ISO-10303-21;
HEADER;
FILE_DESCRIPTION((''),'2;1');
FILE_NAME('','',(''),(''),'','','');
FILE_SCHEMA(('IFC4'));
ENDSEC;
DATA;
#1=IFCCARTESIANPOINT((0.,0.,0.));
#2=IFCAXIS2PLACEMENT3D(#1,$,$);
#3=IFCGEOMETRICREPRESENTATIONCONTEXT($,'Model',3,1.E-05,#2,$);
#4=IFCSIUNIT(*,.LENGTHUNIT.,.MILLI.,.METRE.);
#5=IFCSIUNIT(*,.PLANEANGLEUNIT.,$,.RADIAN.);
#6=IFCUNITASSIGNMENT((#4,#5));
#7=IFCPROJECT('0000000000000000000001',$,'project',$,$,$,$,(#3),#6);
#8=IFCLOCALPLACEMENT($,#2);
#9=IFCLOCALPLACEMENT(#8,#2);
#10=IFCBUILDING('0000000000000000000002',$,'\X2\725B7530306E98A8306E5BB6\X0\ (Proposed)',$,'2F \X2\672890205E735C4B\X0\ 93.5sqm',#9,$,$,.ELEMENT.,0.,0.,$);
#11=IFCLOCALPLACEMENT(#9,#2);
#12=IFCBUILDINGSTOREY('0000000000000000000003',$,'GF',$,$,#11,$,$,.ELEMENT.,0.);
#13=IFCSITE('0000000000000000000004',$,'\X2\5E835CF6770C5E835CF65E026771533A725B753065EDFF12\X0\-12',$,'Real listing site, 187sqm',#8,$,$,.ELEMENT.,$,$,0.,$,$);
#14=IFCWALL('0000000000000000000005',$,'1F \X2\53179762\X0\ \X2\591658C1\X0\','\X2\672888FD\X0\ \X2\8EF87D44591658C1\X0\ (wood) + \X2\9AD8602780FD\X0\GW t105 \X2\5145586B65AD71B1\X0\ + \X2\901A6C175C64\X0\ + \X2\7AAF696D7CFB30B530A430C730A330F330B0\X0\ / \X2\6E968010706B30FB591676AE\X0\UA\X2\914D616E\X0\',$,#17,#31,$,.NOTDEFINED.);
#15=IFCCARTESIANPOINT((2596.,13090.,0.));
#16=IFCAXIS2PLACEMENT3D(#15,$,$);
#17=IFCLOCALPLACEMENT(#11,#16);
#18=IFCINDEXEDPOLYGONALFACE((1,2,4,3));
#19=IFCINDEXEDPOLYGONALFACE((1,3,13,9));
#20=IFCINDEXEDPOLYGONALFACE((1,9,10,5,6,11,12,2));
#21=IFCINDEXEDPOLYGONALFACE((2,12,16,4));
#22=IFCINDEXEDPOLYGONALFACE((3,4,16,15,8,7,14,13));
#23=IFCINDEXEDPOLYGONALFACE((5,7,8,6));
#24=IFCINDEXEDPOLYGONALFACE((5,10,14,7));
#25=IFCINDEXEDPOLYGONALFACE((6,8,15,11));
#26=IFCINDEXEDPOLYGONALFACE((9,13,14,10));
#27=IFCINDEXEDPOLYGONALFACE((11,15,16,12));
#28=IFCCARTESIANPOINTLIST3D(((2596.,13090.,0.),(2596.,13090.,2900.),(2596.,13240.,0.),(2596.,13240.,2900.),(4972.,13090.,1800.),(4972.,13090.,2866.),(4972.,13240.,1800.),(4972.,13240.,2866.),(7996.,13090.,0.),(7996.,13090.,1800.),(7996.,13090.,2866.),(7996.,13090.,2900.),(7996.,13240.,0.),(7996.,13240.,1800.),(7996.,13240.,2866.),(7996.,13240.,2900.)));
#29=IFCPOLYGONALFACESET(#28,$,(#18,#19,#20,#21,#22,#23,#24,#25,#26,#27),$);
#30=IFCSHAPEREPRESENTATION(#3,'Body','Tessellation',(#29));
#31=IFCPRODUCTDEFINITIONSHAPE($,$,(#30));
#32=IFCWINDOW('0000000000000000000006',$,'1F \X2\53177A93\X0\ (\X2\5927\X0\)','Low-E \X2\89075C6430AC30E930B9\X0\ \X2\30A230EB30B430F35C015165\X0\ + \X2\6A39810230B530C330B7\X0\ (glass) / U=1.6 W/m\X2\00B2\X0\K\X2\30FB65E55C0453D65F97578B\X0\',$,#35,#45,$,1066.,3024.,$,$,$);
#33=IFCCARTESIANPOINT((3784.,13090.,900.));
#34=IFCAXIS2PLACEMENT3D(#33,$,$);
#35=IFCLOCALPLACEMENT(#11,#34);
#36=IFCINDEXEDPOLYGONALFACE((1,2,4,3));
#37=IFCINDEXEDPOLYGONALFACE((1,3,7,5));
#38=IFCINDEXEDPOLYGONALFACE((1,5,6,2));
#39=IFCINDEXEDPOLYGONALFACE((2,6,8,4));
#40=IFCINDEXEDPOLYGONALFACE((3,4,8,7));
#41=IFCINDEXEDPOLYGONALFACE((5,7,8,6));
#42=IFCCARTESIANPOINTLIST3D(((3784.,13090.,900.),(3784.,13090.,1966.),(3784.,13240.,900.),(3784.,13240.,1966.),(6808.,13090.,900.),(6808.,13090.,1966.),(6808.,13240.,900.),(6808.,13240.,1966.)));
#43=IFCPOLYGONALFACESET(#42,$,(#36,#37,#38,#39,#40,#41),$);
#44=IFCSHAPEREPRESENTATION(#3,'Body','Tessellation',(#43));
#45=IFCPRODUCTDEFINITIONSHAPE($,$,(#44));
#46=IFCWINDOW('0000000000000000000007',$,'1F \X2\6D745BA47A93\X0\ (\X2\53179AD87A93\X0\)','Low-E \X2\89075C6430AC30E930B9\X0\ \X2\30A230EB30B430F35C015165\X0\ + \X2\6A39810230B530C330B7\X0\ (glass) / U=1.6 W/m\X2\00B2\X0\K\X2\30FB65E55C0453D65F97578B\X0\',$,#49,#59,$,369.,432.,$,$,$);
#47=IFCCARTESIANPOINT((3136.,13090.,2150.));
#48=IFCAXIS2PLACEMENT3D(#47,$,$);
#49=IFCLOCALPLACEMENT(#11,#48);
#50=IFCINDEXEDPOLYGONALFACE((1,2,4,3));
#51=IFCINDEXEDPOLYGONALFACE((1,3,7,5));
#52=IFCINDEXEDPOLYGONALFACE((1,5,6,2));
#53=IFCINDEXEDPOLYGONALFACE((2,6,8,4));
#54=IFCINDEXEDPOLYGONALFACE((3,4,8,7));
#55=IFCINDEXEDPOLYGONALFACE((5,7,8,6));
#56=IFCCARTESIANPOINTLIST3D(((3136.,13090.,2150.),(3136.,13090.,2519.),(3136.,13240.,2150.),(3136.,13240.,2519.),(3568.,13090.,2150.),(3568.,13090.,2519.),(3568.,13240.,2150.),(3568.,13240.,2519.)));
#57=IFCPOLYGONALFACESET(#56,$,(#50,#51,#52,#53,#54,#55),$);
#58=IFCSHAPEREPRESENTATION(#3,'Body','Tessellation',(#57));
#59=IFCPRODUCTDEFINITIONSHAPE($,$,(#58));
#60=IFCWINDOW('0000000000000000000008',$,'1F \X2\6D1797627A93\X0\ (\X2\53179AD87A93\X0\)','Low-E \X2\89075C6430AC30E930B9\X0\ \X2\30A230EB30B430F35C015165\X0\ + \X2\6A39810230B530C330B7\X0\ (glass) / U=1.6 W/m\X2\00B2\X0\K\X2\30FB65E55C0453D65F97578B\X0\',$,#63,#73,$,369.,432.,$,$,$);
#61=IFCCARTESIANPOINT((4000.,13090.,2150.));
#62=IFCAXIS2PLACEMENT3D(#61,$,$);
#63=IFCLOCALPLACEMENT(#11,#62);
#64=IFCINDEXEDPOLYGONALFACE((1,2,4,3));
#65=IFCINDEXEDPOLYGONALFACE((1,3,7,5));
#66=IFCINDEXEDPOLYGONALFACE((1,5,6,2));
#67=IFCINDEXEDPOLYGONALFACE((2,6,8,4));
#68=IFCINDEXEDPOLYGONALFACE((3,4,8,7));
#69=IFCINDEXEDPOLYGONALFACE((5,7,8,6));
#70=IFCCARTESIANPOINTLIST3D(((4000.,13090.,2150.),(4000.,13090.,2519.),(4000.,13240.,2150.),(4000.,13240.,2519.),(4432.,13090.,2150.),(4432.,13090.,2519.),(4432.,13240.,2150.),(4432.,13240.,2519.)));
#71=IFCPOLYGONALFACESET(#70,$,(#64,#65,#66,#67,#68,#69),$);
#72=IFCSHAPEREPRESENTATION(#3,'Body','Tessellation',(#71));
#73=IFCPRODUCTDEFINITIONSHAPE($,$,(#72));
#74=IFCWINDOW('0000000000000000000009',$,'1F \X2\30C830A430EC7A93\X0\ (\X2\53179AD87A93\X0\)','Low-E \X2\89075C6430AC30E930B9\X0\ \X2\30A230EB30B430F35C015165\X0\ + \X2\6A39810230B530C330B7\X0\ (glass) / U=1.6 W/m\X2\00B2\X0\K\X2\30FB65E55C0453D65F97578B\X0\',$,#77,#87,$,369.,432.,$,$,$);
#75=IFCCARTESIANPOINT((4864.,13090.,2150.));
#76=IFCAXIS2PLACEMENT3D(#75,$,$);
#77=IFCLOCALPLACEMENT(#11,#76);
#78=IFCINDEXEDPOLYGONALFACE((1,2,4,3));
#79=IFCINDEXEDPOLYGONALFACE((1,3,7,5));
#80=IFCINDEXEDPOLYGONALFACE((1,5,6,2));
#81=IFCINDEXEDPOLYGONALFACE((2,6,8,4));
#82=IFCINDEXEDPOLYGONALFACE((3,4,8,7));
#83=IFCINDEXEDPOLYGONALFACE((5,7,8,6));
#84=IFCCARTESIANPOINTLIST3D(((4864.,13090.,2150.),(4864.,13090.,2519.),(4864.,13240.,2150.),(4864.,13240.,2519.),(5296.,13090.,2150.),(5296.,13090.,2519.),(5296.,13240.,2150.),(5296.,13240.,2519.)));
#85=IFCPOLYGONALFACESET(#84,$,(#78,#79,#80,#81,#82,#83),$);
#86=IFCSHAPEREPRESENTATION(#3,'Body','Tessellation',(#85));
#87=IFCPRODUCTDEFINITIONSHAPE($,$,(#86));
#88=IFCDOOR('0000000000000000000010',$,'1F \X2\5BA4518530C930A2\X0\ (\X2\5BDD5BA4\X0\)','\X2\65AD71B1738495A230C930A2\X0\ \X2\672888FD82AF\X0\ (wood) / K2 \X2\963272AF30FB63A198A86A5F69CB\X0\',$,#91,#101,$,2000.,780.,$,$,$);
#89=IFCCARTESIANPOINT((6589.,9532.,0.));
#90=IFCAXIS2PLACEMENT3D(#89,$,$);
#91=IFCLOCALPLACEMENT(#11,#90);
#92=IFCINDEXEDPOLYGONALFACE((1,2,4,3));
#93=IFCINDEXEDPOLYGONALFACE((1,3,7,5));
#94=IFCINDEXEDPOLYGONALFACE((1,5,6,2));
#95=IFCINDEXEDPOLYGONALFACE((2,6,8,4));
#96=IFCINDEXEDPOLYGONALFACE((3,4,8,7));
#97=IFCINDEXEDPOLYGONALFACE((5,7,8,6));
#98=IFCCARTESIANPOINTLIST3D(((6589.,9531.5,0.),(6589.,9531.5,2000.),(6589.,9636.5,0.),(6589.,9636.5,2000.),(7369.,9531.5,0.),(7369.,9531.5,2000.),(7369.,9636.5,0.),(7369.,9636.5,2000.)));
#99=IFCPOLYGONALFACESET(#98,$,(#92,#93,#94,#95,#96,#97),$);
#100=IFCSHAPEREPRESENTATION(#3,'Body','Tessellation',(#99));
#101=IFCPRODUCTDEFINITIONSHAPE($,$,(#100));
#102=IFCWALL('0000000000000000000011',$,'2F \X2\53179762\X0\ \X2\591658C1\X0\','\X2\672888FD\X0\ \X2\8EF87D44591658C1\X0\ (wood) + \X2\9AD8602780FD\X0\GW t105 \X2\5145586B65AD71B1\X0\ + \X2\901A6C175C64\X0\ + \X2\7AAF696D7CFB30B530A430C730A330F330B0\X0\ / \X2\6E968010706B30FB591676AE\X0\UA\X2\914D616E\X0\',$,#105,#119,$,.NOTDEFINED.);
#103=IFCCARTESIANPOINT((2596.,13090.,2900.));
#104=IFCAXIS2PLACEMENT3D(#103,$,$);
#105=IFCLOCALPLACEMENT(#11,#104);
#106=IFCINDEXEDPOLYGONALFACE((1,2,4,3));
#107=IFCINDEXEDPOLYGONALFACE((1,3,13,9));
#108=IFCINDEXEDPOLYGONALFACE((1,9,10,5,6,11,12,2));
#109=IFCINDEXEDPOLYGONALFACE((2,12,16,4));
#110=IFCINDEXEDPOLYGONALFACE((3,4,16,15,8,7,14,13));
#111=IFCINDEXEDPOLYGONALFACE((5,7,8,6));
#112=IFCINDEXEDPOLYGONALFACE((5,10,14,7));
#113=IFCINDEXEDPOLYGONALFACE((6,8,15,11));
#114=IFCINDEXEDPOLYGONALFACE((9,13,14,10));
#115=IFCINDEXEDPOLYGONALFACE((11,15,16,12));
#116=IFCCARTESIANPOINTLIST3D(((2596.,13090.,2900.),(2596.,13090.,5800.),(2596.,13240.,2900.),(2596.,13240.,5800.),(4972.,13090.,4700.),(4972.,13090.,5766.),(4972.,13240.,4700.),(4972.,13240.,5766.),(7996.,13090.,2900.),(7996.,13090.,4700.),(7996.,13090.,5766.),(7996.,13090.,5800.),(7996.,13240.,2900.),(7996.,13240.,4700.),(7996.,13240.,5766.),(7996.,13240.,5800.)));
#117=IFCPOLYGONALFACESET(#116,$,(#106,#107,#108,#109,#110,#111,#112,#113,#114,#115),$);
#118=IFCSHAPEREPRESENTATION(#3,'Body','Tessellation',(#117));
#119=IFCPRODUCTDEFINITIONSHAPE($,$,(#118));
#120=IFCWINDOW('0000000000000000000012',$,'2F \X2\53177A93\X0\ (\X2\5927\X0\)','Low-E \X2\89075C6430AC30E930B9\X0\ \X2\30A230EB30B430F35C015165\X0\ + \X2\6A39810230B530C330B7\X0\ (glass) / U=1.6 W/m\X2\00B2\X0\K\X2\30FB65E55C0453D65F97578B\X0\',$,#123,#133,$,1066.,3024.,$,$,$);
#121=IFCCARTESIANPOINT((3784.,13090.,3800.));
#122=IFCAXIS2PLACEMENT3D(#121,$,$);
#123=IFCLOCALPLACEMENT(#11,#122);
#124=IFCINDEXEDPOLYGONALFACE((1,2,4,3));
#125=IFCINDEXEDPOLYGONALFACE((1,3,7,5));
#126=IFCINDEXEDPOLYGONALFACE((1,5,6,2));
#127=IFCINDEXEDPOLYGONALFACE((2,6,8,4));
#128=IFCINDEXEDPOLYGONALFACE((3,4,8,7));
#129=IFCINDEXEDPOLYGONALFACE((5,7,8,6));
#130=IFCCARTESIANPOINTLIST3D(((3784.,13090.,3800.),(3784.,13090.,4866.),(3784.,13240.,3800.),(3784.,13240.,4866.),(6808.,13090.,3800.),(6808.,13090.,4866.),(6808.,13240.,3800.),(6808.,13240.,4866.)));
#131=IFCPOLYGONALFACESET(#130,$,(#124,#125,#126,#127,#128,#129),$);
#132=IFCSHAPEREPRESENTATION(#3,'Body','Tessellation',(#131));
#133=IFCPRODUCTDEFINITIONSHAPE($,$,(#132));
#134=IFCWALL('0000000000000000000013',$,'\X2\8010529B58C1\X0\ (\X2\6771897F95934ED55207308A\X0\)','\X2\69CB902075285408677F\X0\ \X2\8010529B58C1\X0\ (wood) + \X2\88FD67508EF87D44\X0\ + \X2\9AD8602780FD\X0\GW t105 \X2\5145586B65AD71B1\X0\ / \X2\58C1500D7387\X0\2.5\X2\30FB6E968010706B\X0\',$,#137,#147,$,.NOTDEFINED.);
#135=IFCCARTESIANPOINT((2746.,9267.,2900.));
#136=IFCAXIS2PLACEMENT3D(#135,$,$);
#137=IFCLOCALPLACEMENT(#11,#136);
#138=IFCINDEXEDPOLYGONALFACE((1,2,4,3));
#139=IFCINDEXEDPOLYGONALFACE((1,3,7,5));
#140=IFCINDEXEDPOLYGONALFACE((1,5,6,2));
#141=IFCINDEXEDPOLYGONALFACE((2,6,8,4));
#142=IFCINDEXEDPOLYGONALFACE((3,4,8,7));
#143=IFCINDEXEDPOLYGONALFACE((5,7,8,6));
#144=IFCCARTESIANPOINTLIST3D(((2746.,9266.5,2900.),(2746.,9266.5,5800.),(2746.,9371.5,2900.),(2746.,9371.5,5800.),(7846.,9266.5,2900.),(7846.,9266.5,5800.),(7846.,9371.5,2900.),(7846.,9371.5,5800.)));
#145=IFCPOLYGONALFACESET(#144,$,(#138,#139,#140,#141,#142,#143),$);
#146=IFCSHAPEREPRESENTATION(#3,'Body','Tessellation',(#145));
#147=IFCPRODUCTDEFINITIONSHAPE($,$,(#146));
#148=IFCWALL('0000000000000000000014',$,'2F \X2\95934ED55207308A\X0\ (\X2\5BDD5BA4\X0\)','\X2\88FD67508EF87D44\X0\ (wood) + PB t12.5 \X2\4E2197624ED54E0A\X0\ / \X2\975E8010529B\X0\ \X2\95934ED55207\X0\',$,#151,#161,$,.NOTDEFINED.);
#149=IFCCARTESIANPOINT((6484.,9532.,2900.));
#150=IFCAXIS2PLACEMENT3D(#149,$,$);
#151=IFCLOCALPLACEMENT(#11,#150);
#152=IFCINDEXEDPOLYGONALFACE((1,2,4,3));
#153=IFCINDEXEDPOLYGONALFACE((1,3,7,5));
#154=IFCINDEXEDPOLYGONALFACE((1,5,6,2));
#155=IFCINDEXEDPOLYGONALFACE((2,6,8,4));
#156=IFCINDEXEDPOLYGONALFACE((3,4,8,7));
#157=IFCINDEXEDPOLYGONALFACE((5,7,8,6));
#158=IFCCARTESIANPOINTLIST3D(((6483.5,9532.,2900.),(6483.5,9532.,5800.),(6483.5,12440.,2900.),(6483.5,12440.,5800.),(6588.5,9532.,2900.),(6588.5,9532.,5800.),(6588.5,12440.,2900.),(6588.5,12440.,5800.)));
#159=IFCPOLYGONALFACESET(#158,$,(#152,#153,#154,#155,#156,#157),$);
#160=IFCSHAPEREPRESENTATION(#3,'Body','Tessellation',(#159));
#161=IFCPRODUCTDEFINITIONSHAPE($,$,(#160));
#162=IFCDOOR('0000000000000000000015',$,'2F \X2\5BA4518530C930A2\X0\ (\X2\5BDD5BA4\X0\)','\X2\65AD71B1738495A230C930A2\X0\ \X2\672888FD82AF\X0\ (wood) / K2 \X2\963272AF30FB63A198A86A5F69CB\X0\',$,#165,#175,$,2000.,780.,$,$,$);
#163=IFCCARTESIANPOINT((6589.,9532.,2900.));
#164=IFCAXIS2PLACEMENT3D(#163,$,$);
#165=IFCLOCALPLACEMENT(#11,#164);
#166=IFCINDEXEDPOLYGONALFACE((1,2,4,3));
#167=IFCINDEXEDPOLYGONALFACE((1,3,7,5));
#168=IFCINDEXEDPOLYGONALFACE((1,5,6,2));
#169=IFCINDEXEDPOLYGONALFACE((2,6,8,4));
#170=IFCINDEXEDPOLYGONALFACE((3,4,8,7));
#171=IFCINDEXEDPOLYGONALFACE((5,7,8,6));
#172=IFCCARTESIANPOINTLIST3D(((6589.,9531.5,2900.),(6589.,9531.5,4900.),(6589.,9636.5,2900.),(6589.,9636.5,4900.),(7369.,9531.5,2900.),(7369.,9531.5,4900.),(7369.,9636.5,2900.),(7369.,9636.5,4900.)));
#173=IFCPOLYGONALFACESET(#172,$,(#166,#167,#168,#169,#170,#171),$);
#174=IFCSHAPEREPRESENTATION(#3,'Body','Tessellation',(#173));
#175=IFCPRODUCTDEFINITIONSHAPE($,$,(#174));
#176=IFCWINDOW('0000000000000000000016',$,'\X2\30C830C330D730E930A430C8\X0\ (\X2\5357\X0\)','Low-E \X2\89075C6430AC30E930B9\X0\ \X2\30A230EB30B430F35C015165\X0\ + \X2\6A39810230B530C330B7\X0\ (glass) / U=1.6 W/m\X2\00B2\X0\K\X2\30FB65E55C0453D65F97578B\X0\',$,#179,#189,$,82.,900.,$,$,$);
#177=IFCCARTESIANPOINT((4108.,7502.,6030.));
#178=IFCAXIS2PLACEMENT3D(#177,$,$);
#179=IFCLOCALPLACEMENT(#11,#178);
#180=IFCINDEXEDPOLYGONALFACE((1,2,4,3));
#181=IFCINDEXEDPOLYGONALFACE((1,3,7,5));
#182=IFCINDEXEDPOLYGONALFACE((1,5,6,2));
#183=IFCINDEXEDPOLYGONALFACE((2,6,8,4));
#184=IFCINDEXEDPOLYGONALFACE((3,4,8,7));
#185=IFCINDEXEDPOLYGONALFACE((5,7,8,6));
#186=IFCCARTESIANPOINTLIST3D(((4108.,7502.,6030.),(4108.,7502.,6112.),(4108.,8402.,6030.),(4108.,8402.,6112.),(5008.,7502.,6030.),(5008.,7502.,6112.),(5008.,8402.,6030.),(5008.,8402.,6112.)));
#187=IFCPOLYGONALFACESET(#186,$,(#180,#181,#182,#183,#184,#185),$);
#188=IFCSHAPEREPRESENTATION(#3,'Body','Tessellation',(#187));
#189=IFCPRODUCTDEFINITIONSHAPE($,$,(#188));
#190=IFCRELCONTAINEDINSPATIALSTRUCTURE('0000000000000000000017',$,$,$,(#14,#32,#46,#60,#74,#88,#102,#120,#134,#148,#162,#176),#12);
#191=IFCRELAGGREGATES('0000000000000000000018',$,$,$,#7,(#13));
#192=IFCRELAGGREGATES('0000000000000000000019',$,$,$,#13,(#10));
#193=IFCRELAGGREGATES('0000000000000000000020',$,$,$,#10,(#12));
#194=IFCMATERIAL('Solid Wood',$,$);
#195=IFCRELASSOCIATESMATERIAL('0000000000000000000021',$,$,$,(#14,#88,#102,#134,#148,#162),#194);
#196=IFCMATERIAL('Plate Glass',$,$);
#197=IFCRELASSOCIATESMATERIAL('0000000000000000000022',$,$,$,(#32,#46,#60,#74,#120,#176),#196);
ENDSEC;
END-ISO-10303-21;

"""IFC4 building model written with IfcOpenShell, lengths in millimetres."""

from ifc_helpers import new_model, si_unit, frame, frame_2d, origin, place, context, project, spatial, rectangle, extrude, material, element, fill, save


model = new_model("IFC4")

# Units and contexts
model_context = context("Model", 3, precision=1e-05, world=origin())
ifc_project = project(units=[si_unit("LENGTHUNIT", "METRE", prefix="MILLI"), si_unit("PLANEANGLEUNIT", "RADIAN")], contexts=[model_context])

# Site, building, storey
site_placement = place(None, origin())
site = spatial("IfcSite", under=ifc_project, at=site_placement, Name="広島県広島市東区牛田旭２-12", ObjectType="Real listing site, 187sqm", CompositionType="ELEMENT", RefElevation=0.0)
building_placement = place(site_placement, origin())
building = spatial("IfcBuilding", under=site, at=building_placement, Name="牛田の風の家 (Proposed)", ObjectType="2F 木造平屋 93.5sqm", CompositionType="ELEMENT", ElevationOfRefHeight=0.0, ElevationOfTerrain=0.0)
storey_placement = place(building_placement, origin())
storey = spatial("IfcBuildingStorey", under=building, at=storey_placement, Name="GF", CompositionType="ELEMENT", Elevation=0.0)

# Wall, openings, windows
ifc_material_1 = material(Name="Solid Wood")
wall_1_placement = place(storey_placement, frame((2596.0, 13090.0, 0.0)))
wall_1 = element("IfcWall", 1, at=wall_1_placement, inside=storey, material=ifc_material_1, Name="1F 北面 外壁", Description="木製 軸組外壁 (wood) + 高性能GW t105 充填断熱 + 通気層 + 窯業系サイディング / 準耐火・外皮UA配慮", PredefinedType="NOTDEFINED", context=model_context, shape_type="SweptSolid", body=[
    extrude(rectangle(XDim=5400.0, YDim=150.0, at=frame_2d((2700.0, 75.0))), frame((2596.0, 13090.0, 0.0)), (0.0, 0.0, 1.0), 2900.0),
])
opening_1_placement = place(storey_placement, frame((3784.0, 13090.0, 900.0)))
opening_1 = element("IfcOpeningElement", 2, at=opening_1_placement, cuts=wall_1, PredefinedType="NOTDEFINED", context=model_context, shape_type="SweptSolid", body=[
    extrude(rectangle(XDim=3024.0, YDim=150.0, at=frame_2d((1512.0, 75.0))), frame((3784.0, 13090.0, 900.0)), (0.0, 0.0, 1.0), 1066.0),
])
opening_2_placement = place(storey_placement, frame((3136.0, 13090.0, 2150.0)))
opening_2 = element("IfcOpeningElement", 3, at=opening_2_placement, cuts=wall_1, PredefinedType="NOTDEFINED", context=model_context, shape_type="SweptSolid", body=[
    extrude(rectangle(XDim=432.0, YDim=150.0, at=frame_2d((216.0, 75.0))), frame((3136.0, 13090.0, 2150.0)), (0.0, 0.0, 1.0), 369.0),
])
opening_3_placement = place(storey_placement, frame((4000.0, 13090.0, 2150.0)))
opening_3 = element("IfcOpeningElement", 4, at=opening_3_placement, cuts=wall_1, PredefinedType="NOTDEFINED", context=model_context, shape_type="SweptSolid", body=[
    extrude(rectangle(XDim=432.0, YDim=150.0, at=frame_2d((216.0, 75.0))), frame((4000.0, 13090.0, 2150.0)), (0.0, 0.0, 1.0), 369.0),
])
opening_4_placement = place(storey_placement, frame((4864.0, 13090.0, 2150.0)))
opening_4 = element("IfcOpeningElement", 5, at=opening_4_placement, cuts=wall_1, PredefinedType="NOTDEFINED", context=model_context, shape_type="SweptSolid", body=[
    extrude(rectangle(XDim=432.0, YDim=150.0, at=frame_2d((216.0, 75.0))), frame((4864.0, 13090.0, 2150.0)), (0.0, 0.0, 1.0), 369.0),
])
ifc_material_2 = material(Name="Plate Glass")
window_1_placement = place(storey_placement, frame((3784.0, 13090.0, 900.0)))
window_1 = element("IfcWindow", 6, at=window_1_placement, inside=storey, material=ifc_material_2, Name="1F 北窓 (大)", Description="Low-E 複層ガラス アルゴン封入 + 樹脂サッシ (glass) / U=1.6 W/m²K・日射取得型", OverallHeight=1066.0, OverallWidth=3024.0, context=model_context, shape_type="SweptSolid", body=[
    extrude(rectangle(XDim=3024.0, YDim=150.0, at=frame_2d((1512.0, 75.0))), frame((3784.0, 13090.0, 900.0)), (0.0, 0.0, 1.0), 1066.0),
])
fill(opening_1, window_1)
window_2_placement = place(storey_placement, frame((3136.0, 13090.0, 2150.0)))
window_2 = element("IfcWindow", 7, at=window_2_placement, inside=storey, material=ifc_material_2, Name="1F 浴室窓 (北高窓)", Description="Low-E 複層ガラス アルゴン封入 + 樹脂サッシ (glass) / U=1.6 W/m²K・日射取得型", OverallHeight=369.0, OverallWidth=432.0, context=model_context, shape_type="SweptSolid", body=[
    extrude(rectangle(XDim=432.0, YDim=150.0, at=frame_2d((216.0, 75.0))), frame((3136.0, 13090.0, 2150.0)), (0.0, 0.0, 1.0), 369.0),
])
fill(opening_2, window_2)
window_3_placement = place(storey_placement, frame((4000.0, 13090.0, 2150.0)))
window_3 = element("IfcWindow", 8, at=window_3_placement, inside=storey, material=ifc_material_2, Name="1F 洗面窓 (北高窓)", Description="Low-E 複層ガラス アルゴン封入 + 樹脂サッシ (glass) / U=1.6 W/m²K・日射取得型", OverallHeight=369.0, OverallWidth=432.0, context=model_context, shape_type="SweptSolid", body=[
    extrude(rectangle(XDim=432.0, YDim=150.0, at=frame_2d((216.0, 75.0))), frame((4000.0, 13090.0, 2150.0)), (0.0, 0.0, 1.0), 369.0),
])
fill(opening_3, window_3)
window_4_placement = place(storey_placement, frame((4864.0, 13090.0, 2150.0)))
window_4 = element("IfcWindow", 9, at=window_4_placement, inside=storey, material=ifc_material_2, Name="1F トイレ窓 (北高窓)", Description="Low-E 複層ガラス アルゴン封入 + 樹脂サッシ (glass) / U=1.6 W/m²K・日射取得型", OverallHeight=369.0, OverallWidth=432.0, context=model_context, shape_type="SweptSolid", body=[
    extrude(rectangle(XDim=432.0, YDim=150.0, at=frame_2d((216.0, 75.0))), frame((4864.0, 13090.0, 2150.0)), (0.0, 0.0, 1.0), 369.0),
])
fill(opening_4, window_4)

# Door
door_1_placement = place(storey_placement, frame((6589.0, 9532.0, 0.0)))
element("IfcDoor", 10, at=door_1_placement, inside=storey, material=ifc_material_1, Name="1F 室内ドア (寝室)", Description="断熱玄関ドア 木製芯 (wood) / K2 防犯・採風機構", OverallHeight=2000.0, OverallWidth=780.0, context=model_context, shape_type="SweptSolid", body=[
    extrude(rectangle(XDim=780.0, YDim=105.0, at=frame_2d((390.0, 52.0))), frame((6589.0, 9532.0, 0.0)), (0.0, 0.0, 1.0), 2000.0),
])

# Wall, opening, window
wall_2_placement = place(storey_placement, frame((2596.0, 13090.0, 2900.0)))
wall_2 = element("IfcWall", 11, at=wall_2_placement, inside=storey, material=ifc_material_1, Name="2F 北面 外壁", Description="木製 軸組外壁 (wood) + 高性能GW t105 充填断熱 + 通気層 + 窯業系サイディング / 準耐火・外皮UA配慮", PredefinedType="NOTDEFINED", context=model_context, shape_type="SweptSolid", body=[
    extrude(rectangle(XDim=5400.0, YDim=150.0, at=frame_2d((2700.0, 75.0))), frame((2596.0, 13090.0, 2900.0)), (0.0, 0.0, 1.0), 2900.0),
])
opening_5_placement = place(storey_placement, frame((3784.0, 13090.0, 3800.0)))
opening_5 = element("IfcOpeningElement", 12, at=opening_5_placement, cuts=wall_2, PredefinedType="NOTDEFINED", context=model_context, shape_type="SweptSolid", body=[
    extrude(rectangle(XDim=3024.0, YDim=150.0, at=frame_2d((1512.0, 75.0))), frame((3784.0, 13090.0, 3800.0)), (0.0, 0.0, 1.0), 1066.0),
])
window_5_placement = place(storey_placement, frame((3784.0, 13090.0, 3800.0)))
window_5 = element("IfcWindow", 13, at=window_5_placement, inside=storey, material=ifc_material_2, Name="2F 北窓 (大)", Description="Low-E 複層ガラス アルゴン封入 + 樹脂サッシ (glass) / U=1.6 W/m²K・日射取得型", OverallHeight=1066.0, OverallWidth=3024.0, context=model_context, shape_type="SweptSolid", body=[
    extrude(rectangle(XDim=3024.0, YDim=150.0, at=frame_2d((1512.0, 75.0))), frame((3784.0, 13090.0, 3800.0)), (0.0, 0.0, 1.0), 1066.0),
])
fill(opening_5, window_5)

# Walls
wall_3_placement = place(storey_placement, frame((2746.0, 9267.0, 2900.0)))
element("IfcWall", 14, at=wall_3_placement, inside=storey, material=ifc_material_1, Name="耐力壁 (東西間仕切り)", Description="構造用合板 耐力壁 (wood) + 製材軸組 + 高性能GW t105 充填断熱 / 壁倍率2.5・準耐火", PredefinedType="NOTDEFINED", context=model_context, shape_type="SweptSolid", body=[
    extrude(rectangle(XDim=5100.0, YDim=105.0, at=frame_2d((2550.0, 52.0))), frame((2746.0, 9267.0, 2900.0)), (0.0, 0.0, 1.0), 2900.0),
])
wall_4_placement = place(storey_placement, frame((6484.0, 9532.0, 2900.0)))
element("IfcWall", 15, at=wall_4_placement, inside=storey, material=ifc_material_1, Name="2F 間仕切り (寝室)", Description="製材軸組 (wood) + PB t12.5 両面仕上 / 非耐力 間仕切", PredefinedType="NOTDEFINED", context=model_context, shape_type="SweptSolid", body=[
    extrude(rectangle(XDim=105.0, YDim=2908.0, at=frame_2d((52.0, 1454.0))), frame((6484.0, 9532.0, 2900.0)), (0.0, 0.0, 1.0), 2900.0),
])

# Door
door_2_placement = place(storey_placement, frame((6589.0, 9532.0, 2900.0)))
element("IfcDoor", 16, at=door_2_placement, inside=storey, material=ifc_material_1, Name="2F 室内ドア (寝室)", Description="断熱玄関ドア 木製芯 (wood) / K2 防犯・採風機構", OverallHeight=2000.0, OverallWidth=780.0, context=model_context, shape_type="SweptSolid", body=[
    extrude(rectangle(XDim=780.0, YDim=105.0, at=frame_2d((390.0, 52.0))), frame((6589.0, 9532.0, 2900.0)), (0.0, 0.0, 1.0), 2000.0),
])

# Window
window_6_placement = place(storey_placement, frame((4108.0, 7502.0, 6030.0)))
element("IfcWindow", 17, at=window_6_placement, inside=storey, material=ifc_material_2, Name="トップライト (南)", Description="Low-E 複層ガラス アルゴン封入 + 樹脂サッシ (glass) / U=1.6 W/m²K・日射取得型", OverallHeight=82.0, OverallWidth=900.0, context=model_context, shape_type="SweptSolid", body=[
    extrude(rectangle(XDim=900.0, YDim=900.0, at=frame_2d((450.0, 450.0))), frame((4108.0, 7502.0, 6030.0)), (0.0, 0.0, 1.0), 82.0),
])

save(model, "model.ifc")
